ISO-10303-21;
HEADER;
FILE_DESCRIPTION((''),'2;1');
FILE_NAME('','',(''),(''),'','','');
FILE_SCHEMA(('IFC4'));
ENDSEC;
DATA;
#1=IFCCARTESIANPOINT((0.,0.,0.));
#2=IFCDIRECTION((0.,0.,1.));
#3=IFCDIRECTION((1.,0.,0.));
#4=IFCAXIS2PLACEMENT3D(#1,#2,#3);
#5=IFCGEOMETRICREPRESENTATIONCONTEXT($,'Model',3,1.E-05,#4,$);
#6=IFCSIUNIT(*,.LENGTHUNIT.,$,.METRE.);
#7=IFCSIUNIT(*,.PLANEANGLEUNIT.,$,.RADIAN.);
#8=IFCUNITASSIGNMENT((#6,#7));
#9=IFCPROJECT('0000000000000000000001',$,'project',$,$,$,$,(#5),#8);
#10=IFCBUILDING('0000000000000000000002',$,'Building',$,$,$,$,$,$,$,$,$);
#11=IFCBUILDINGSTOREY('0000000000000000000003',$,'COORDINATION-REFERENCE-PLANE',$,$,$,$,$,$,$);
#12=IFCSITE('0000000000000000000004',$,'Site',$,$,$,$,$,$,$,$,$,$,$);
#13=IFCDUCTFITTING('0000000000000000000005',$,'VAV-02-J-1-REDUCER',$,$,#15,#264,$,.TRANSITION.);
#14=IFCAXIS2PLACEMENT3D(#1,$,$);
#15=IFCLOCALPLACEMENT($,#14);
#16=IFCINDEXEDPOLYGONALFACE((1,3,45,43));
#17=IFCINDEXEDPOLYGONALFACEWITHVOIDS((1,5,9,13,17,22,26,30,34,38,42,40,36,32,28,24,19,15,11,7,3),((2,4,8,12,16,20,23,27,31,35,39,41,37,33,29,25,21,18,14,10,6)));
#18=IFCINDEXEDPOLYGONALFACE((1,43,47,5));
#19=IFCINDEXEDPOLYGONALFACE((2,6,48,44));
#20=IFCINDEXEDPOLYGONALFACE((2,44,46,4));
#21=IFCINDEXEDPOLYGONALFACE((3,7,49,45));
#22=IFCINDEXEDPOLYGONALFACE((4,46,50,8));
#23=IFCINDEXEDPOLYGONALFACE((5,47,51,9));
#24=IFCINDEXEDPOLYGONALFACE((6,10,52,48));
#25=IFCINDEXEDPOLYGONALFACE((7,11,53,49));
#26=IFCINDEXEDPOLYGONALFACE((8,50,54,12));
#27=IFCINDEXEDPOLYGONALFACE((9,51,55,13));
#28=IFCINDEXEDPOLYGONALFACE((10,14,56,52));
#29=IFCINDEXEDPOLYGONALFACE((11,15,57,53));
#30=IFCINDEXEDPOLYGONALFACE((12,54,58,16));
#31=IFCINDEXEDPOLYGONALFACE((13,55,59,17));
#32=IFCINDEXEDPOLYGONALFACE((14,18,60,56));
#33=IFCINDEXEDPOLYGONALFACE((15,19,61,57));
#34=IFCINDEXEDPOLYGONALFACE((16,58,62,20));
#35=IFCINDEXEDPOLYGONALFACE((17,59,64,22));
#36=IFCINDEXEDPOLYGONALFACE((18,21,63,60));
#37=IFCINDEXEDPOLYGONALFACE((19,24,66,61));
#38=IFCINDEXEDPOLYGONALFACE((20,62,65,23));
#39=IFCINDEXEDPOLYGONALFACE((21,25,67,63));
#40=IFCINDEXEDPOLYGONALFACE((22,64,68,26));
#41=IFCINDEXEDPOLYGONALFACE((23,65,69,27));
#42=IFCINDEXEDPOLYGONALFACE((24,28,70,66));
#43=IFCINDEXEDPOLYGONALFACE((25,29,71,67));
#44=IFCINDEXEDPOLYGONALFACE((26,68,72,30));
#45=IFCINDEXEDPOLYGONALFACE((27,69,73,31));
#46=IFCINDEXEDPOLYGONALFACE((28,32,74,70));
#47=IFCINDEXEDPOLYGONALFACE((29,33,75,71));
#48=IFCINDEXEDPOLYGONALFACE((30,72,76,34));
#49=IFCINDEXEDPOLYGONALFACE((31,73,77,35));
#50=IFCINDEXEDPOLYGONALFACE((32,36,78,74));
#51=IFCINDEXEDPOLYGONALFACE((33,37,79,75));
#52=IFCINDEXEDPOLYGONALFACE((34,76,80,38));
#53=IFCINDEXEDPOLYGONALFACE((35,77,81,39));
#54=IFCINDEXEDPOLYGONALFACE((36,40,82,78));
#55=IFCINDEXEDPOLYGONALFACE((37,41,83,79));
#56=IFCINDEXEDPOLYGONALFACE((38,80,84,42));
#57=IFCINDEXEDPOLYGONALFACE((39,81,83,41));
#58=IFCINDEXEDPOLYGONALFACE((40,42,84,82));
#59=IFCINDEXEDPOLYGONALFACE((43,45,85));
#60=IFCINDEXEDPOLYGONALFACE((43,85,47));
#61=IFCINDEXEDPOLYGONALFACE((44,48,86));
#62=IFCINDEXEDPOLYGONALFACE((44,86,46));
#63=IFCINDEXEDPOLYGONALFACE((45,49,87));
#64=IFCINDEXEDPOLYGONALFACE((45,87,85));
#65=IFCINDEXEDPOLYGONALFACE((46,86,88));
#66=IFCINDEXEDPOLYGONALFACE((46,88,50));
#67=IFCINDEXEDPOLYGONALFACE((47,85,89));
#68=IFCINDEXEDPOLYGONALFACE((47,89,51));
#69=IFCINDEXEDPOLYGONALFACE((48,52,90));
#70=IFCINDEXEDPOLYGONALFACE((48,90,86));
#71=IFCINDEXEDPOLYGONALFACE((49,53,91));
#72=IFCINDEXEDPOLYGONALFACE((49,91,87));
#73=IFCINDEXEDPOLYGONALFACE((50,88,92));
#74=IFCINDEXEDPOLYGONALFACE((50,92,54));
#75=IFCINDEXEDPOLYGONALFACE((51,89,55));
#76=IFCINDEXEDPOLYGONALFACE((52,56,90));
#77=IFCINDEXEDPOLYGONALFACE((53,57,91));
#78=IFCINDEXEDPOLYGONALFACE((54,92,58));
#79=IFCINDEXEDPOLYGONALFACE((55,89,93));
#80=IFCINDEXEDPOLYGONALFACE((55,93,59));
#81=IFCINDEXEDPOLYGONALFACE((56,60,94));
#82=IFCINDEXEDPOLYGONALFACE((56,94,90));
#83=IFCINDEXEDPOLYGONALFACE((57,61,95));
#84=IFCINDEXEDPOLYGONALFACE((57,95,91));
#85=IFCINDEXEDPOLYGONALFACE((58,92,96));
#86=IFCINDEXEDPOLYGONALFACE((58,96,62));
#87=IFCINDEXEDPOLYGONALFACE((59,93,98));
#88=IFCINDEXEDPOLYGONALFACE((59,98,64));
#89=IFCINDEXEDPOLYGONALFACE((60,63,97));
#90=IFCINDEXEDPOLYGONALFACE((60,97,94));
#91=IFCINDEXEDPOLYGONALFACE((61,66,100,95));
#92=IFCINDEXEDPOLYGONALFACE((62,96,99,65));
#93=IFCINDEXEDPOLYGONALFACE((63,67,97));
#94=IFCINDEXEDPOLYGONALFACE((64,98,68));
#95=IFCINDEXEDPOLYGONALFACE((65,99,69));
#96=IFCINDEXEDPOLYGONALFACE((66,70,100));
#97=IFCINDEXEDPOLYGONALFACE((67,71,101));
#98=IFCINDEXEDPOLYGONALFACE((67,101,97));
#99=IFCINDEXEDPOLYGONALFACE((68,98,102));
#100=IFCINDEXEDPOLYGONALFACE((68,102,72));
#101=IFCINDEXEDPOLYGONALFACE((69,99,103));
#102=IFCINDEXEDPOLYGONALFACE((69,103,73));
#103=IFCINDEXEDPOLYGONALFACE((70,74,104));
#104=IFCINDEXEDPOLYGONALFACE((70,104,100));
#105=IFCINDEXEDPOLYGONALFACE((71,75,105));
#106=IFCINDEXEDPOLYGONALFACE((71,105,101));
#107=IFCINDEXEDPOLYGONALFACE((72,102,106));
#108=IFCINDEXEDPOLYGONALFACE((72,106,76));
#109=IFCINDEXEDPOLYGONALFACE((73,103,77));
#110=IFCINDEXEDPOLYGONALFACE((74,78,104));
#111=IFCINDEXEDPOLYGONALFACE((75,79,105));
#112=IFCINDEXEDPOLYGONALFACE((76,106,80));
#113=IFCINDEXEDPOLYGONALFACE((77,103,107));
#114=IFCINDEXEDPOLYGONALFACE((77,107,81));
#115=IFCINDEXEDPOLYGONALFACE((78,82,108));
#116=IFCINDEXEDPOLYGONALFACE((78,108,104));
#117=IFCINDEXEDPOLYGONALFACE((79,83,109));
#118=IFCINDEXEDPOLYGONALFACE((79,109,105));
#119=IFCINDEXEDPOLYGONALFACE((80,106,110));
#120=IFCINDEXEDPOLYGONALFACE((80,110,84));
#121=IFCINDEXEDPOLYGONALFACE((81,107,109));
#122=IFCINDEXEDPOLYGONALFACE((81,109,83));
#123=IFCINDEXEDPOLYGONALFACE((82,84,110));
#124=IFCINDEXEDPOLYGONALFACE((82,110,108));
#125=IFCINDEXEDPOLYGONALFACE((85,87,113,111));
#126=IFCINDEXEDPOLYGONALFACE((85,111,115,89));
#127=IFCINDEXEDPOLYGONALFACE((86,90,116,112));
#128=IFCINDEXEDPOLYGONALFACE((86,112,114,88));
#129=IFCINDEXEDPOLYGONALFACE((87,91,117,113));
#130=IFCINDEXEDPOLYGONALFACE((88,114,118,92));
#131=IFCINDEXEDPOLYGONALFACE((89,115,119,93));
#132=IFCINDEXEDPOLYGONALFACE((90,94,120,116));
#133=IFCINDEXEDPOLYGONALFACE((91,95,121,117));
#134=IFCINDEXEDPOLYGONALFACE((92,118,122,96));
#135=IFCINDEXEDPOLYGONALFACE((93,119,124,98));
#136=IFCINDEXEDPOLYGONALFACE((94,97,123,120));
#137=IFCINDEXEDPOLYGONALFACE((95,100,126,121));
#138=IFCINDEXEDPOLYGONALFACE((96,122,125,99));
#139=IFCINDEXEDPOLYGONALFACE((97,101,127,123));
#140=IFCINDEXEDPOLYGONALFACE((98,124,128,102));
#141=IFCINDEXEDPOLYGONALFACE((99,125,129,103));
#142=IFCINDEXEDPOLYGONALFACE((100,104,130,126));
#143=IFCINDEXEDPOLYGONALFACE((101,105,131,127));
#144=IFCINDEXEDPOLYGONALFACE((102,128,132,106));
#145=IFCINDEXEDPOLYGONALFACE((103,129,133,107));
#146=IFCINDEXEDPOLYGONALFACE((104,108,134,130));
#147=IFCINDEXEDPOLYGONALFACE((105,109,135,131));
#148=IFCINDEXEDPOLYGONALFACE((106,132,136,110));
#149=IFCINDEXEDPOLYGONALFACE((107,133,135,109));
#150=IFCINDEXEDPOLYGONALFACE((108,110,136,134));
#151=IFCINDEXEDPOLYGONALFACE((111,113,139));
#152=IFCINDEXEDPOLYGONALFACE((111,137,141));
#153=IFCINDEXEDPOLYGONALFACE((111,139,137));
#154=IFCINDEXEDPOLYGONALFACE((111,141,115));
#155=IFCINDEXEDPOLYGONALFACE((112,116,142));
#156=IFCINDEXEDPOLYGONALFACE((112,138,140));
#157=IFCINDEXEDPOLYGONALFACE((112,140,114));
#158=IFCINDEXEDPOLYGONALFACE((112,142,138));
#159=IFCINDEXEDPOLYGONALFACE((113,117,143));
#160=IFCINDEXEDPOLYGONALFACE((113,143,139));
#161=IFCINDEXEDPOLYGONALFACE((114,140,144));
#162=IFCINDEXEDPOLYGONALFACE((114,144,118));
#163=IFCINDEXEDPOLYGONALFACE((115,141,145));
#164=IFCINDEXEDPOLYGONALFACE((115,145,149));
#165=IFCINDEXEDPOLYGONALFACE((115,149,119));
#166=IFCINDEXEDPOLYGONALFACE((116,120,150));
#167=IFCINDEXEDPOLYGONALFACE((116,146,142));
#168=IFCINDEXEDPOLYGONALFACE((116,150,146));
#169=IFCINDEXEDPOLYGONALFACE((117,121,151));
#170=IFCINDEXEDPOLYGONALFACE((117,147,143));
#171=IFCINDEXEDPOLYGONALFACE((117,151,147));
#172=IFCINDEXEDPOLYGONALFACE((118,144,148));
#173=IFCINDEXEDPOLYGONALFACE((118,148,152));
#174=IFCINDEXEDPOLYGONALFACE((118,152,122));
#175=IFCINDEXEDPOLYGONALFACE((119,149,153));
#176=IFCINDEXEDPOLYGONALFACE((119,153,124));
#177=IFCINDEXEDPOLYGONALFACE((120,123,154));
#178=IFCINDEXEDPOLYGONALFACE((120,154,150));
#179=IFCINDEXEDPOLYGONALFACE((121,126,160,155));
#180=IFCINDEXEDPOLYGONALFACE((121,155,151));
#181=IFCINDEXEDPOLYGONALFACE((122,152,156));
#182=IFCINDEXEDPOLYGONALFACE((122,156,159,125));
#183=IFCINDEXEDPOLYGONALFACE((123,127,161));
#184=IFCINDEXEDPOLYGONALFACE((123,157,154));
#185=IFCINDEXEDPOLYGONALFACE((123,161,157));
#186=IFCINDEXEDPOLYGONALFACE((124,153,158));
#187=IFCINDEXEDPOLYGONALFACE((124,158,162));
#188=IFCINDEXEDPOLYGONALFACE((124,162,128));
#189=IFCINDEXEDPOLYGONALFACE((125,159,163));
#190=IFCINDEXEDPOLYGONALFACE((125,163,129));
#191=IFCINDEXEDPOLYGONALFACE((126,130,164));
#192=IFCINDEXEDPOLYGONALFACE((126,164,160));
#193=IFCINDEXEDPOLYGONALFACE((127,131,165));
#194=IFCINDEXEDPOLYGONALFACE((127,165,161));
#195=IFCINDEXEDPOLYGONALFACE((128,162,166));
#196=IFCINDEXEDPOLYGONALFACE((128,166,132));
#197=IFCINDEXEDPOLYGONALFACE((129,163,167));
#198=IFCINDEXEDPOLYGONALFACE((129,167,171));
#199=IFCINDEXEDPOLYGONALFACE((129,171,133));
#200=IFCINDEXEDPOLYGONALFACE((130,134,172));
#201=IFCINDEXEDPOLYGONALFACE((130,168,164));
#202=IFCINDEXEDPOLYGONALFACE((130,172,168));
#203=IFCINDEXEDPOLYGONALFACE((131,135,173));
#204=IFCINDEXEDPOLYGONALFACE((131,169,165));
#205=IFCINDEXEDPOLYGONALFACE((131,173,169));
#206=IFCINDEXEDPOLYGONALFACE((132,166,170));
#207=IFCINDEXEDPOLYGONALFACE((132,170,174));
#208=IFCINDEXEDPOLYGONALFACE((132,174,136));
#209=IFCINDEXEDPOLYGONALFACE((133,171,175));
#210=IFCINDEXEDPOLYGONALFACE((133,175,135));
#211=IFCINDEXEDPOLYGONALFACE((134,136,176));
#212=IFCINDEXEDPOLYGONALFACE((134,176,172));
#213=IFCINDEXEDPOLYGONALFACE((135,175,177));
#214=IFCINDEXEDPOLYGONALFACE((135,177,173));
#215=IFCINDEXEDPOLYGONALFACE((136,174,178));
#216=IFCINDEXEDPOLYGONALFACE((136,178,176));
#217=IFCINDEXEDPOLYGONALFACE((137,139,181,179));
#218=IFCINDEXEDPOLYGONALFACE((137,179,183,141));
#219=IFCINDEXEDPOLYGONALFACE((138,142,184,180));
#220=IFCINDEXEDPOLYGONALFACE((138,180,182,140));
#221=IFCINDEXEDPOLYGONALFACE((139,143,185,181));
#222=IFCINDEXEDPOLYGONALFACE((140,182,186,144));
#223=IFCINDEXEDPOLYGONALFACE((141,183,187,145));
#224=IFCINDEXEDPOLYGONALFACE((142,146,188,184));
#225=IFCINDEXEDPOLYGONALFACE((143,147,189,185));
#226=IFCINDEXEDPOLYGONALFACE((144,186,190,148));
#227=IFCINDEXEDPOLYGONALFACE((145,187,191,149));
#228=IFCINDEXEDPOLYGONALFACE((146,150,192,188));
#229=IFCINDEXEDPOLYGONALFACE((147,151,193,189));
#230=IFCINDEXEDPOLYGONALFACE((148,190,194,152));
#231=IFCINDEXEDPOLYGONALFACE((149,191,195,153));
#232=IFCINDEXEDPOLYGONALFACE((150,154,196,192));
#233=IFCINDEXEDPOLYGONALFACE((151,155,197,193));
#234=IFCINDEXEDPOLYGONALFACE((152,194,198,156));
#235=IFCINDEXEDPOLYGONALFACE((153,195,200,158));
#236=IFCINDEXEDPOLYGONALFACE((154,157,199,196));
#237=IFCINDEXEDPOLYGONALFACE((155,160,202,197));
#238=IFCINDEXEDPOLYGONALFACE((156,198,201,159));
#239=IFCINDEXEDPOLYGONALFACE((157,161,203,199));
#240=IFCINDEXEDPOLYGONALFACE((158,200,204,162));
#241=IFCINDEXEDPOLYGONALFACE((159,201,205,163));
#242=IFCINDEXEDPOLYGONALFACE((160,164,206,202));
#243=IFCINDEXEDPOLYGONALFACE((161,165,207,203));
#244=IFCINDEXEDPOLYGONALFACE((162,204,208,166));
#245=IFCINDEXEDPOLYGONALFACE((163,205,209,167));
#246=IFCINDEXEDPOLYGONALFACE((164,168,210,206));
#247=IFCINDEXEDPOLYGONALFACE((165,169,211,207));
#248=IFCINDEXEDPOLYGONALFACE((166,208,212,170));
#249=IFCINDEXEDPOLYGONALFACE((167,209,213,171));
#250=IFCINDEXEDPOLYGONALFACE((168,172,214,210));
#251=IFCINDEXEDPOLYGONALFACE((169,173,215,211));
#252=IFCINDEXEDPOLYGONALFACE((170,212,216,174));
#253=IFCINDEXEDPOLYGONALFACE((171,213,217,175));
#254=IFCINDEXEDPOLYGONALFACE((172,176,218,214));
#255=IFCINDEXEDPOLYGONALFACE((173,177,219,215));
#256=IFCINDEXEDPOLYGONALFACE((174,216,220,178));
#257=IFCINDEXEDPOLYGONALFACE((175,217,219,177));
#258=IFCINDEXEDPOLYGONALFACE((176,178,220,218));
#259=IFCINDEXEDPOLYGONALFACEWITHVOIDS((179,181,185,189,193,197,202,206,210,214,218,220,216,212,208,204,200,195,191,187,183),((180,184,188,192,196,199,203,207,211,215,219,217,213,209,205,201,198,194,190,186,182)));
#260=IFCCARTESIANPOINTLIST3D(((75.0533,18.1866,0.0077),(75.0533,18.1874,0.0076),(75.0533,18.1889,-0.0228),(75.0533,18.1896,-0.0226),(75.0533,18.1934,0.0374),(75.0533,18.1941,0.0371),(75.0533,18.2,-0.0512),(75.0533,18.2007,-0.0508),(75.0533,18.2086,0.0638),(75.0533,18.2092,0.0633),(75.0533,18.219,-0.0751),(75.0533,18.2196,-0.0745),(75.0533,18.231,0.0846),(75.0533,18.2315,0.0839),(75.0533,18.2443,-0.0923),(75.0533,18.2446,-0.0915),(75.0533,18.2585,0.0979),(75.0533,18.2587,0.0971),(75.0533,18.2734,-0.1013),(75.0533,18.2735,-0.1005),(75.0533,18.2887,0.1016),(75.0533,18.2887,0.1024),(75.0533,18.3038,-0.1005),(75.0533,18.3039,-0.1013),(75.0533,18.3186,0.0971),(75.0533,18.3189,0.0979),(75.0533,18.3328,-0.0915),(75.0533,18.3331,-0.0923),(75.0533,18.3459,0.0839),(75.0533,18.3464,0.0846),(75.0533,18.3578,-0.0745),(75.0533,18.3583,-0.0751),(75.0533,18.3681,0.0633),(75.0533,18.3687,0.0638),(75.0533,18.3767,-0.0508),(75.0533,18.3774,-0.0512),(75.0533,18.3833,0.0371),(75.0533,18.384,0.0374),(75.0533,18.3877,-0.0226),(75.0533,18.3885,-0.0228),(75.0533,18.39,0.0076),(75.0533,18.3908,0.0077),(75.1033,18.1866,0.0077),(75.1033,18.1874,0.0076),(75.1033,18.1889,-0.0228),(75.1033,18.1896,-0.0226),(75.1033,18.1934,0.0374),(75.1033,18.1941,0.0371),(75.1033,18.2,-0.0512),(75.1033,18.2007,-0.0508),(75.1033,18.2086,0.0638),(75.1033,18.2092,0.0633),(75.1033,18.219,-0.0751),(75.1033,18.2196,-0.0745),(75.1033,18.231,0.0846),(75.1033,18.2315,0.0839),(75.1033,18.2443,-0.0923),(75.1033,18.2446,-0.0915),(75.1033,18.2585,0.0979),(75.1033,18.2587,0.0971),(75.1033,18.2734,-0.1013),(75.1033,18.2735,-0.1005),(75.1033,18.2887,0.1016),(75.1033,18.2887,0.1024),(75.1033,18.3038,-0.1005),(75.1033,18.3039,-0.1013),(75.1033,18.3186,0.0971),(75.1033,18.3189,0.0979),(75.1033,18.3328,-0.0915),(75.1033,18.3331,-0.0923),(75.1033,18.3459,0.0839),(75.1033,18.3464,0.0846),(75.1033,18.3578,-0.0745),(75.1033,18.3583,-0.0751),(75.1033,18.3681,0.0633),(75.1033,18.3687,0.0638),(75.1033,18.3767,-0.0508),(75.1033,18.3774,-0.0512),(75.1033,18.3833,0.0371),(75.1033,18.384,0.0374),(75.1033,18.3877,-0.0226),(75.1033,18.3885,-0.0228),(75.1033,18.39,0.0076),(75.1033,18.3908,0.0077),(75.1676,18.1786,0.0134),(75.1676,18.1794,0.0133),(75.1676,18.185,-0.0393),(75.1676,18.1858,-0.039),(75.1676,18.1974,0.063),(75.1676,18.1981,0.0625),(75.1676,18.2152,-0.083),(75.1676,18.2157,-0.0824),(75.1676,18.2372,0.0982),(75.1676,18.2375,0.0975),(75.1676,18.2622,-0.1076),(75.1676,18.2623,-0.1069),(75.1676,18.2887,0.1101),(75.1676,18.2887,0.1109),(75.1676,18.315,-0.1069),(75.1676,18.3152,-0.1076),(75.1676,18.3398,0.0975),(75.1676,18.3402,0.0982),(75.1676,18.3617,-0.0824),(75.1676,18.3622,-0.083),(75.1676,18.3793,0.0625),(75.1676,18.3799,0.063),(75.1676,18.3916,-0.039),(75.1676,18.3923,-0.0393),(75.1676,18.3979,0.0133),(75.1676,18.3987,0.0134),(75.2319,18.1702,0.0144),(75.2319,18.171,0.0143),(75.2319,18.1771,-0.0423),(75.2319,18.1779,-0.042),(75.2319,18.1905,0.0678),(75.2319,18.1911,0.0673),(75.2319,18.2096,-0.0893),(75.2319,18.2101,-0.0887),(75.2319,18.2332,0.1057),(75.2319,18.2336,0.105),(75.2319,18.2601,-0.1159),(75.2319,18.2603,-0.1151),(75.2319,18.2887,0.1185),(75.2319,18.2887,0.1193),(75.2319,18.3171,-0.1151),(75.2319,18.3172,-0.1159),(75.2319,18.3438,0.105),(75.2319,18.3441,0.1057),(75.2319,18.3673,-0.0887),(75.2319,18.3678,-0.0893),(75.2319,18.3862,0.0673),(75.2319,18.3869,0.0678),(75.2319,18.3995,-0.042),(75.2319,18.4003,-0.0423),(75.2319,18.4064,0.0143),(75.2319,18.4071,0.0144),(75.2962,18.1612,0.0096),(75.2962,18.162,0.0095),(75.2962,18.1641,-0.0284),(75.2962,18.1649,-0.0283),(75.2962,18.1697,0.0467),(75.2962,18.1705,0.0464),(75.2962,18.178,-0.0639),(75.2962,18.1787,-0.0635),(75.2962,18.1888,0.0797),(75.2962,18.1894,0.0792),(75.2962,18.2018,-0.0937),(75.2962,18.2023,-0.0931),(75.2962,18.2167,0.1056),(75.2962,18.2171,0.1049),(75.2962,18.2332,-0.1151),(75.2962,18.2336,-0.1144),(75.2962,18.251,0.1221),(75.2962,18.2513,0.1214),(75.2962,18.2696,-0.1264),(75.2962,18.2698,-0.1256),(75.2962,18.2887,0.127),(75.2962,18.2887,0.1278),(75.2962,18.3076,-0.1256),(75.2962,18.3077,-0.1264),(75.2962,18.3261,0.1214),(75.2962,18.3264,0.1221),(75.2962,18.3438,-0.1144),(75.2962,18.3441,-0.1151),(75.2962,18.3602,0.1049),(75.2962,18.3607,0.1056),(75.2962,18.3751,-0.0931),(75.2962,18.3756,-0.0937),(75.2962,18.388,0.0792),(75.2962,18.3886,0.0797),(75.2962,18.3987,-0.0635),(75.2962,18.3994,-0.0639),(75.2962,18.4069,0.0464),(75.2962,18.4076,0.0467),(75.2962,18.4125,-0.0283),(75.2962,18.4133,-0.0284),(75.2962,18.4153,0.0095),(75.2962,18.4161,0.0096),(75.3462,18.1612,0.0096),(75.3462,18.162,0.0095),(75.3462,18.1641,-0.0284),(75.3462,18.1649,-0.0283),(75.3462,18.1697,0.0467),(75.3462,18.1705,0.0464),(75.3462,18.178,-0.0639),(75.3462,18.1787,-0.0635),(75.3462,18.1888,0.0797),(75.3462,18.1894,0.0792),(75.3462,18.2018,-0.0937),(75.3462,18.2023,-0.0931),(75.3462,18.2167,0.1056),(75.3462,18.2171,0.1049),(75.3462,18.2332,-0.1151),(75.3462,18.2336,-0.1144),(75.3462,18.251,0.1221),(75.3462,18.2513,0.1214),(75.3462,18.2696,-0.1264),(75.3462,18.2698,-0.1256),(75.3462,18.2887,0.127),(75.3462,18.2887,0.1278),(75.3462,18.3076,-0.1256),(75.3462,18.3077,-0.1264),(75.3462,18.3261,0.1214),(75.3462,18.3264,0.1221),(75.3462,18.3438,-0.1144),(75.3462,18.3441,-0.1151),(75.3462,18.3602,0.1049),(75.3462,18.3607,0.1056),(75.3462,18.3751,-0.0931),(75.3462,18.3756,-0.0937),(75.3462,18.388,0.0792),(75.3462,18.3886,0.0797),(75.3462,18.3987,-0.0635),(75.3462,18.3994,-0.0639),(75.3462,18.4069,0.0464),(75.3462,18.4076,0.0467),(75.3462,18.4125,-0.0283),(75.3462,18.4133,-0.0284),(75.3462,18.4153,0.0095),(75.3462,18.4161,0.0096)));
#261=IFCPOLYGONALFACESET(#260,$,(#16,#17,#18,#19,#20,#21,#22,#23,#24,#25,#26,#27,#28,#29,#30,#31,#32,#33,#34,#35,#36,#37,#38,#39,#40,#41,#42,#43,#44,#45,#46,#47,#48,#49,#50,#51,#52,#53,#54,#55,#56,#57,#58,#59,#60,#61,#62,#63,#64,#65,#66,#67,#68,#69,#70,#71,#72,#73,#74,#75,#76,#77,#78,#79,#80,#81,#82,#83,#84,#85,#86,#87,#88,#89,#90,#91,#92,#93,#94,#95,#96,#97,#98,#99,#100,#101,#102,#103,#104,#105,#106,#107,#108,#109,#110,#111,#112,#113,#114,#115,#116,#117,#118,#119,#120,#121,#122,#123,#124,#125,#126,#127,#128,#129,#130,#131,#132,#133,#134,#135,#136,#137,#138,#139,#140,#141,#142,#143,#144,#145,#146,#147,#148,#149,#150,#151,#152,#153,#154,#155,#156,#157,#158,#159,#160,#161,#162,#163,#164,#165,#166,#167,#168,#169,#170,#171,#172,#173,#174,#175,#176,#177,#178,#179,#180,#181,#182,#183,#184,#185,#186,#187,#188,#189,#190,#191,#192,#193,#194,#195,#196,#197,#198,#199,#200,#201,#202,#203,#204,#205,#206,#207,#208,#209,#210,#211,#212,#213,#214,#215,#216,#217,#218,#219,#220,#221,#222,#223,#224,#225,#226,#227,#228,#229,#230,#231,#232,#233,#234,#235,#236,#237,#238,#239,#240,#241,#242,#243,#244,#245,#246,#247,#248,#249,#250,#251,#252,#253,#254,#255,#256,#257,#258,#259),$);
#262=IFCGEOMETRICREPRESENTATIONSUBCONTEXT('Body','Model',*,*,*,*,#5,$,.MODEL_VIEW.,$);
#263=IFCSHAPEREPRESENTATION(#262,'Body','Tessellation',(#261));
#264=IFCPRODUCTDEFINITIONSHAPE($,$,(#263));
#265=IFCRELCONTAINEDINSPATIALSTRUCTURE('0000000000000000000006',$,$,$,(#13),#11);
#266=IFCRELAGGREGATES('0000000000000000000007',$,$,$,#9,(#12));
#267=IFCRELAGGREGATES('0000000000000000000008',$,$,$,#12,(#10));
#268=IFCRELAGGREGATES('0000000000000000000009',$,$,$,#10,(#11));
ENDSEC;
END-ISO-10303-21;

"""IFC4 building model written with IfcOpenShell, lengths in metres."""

from ifc_helpers import new_model, entity, si_unit, frame, origin_with_axes, place, context, subcontext, project, spatial, element, save


model = new_model("IFC4")

# Units and contexts
model_context_1 = context("Model", 3, precision=1e-05, world=origin_with_axes())
body_context_1 = subcontext(model_context_1, "Body", "Model", "MODEL_VIEW")
ifc_project = project(units=[si_unit("LENGTHUNIT", "METRE"), si_unit("PLANEANGLEUNIT", "RADIAN")], contexts=[model_context_1])

# Site, building, storey
site = spatial("IfcSite", under=ifc_project, Name="Site")
building = spatial("IfcBuilding", under=site, Name="Building")
storey = spatial("IfcBuildingStorey", under=building, Name="COORDINATION-REFERENCE-PLANE")

# Duct fitting
for number, where, z_axis, x_axis, name in (
    (1, (75.3462, 18.2887, 0.0), (0.0, -1.0, 0.0), (0.0, 0.0, 1.0), "VAV-02-J-1-REDUCER"),
):
    element("IfcDuctFitting", number, at=place(None, frame(where, z_axis=z_axis, x_axis=x_axis)), inside=storey, Name=name, PredefinedType="TRANSITION", context=body_context_1, shape_type="SweptSolid", body=[
        entity("IfcRevolvedAreaSolid", entity("IfcArbitraryClosedProfileDef", "AREA", None, entity("IfcPolyline", [entity("IfcCartesianPoint", [0.1278, 0.0]), entity("IfcCartesianPoint", [0.1278, 0.05]), entity("IfcCartesianPoint", [0.1024, 0.2429]), entity("IfcCartesianPoint", [0.1024, 0.2929]), entity("IfcCartesianPoint", [0.1016, 0.2929]), entity("IfcCartesianPoint", [0.1016, 0.2429]), entity("IfcCartesianPoint", [0.127, 0.05]), entity("IfcCartesianPoint", [0.127, 0.0]), entity("IfcCartesianPoint", [0.1278, 0.0])])), entity("IfcAxis2Placement3D", entity("IfcCartesianPoint", [0.0, 0.0, 0.0])), entity("IfcAxis1Placement", entity("IfcCartesianPoint", [0.0, 0.0, 0.0]), entity("IfcDirection", [0.0, 1.0, 0.0])), 6.283185),
    ])

save(model, "model.ifc")
